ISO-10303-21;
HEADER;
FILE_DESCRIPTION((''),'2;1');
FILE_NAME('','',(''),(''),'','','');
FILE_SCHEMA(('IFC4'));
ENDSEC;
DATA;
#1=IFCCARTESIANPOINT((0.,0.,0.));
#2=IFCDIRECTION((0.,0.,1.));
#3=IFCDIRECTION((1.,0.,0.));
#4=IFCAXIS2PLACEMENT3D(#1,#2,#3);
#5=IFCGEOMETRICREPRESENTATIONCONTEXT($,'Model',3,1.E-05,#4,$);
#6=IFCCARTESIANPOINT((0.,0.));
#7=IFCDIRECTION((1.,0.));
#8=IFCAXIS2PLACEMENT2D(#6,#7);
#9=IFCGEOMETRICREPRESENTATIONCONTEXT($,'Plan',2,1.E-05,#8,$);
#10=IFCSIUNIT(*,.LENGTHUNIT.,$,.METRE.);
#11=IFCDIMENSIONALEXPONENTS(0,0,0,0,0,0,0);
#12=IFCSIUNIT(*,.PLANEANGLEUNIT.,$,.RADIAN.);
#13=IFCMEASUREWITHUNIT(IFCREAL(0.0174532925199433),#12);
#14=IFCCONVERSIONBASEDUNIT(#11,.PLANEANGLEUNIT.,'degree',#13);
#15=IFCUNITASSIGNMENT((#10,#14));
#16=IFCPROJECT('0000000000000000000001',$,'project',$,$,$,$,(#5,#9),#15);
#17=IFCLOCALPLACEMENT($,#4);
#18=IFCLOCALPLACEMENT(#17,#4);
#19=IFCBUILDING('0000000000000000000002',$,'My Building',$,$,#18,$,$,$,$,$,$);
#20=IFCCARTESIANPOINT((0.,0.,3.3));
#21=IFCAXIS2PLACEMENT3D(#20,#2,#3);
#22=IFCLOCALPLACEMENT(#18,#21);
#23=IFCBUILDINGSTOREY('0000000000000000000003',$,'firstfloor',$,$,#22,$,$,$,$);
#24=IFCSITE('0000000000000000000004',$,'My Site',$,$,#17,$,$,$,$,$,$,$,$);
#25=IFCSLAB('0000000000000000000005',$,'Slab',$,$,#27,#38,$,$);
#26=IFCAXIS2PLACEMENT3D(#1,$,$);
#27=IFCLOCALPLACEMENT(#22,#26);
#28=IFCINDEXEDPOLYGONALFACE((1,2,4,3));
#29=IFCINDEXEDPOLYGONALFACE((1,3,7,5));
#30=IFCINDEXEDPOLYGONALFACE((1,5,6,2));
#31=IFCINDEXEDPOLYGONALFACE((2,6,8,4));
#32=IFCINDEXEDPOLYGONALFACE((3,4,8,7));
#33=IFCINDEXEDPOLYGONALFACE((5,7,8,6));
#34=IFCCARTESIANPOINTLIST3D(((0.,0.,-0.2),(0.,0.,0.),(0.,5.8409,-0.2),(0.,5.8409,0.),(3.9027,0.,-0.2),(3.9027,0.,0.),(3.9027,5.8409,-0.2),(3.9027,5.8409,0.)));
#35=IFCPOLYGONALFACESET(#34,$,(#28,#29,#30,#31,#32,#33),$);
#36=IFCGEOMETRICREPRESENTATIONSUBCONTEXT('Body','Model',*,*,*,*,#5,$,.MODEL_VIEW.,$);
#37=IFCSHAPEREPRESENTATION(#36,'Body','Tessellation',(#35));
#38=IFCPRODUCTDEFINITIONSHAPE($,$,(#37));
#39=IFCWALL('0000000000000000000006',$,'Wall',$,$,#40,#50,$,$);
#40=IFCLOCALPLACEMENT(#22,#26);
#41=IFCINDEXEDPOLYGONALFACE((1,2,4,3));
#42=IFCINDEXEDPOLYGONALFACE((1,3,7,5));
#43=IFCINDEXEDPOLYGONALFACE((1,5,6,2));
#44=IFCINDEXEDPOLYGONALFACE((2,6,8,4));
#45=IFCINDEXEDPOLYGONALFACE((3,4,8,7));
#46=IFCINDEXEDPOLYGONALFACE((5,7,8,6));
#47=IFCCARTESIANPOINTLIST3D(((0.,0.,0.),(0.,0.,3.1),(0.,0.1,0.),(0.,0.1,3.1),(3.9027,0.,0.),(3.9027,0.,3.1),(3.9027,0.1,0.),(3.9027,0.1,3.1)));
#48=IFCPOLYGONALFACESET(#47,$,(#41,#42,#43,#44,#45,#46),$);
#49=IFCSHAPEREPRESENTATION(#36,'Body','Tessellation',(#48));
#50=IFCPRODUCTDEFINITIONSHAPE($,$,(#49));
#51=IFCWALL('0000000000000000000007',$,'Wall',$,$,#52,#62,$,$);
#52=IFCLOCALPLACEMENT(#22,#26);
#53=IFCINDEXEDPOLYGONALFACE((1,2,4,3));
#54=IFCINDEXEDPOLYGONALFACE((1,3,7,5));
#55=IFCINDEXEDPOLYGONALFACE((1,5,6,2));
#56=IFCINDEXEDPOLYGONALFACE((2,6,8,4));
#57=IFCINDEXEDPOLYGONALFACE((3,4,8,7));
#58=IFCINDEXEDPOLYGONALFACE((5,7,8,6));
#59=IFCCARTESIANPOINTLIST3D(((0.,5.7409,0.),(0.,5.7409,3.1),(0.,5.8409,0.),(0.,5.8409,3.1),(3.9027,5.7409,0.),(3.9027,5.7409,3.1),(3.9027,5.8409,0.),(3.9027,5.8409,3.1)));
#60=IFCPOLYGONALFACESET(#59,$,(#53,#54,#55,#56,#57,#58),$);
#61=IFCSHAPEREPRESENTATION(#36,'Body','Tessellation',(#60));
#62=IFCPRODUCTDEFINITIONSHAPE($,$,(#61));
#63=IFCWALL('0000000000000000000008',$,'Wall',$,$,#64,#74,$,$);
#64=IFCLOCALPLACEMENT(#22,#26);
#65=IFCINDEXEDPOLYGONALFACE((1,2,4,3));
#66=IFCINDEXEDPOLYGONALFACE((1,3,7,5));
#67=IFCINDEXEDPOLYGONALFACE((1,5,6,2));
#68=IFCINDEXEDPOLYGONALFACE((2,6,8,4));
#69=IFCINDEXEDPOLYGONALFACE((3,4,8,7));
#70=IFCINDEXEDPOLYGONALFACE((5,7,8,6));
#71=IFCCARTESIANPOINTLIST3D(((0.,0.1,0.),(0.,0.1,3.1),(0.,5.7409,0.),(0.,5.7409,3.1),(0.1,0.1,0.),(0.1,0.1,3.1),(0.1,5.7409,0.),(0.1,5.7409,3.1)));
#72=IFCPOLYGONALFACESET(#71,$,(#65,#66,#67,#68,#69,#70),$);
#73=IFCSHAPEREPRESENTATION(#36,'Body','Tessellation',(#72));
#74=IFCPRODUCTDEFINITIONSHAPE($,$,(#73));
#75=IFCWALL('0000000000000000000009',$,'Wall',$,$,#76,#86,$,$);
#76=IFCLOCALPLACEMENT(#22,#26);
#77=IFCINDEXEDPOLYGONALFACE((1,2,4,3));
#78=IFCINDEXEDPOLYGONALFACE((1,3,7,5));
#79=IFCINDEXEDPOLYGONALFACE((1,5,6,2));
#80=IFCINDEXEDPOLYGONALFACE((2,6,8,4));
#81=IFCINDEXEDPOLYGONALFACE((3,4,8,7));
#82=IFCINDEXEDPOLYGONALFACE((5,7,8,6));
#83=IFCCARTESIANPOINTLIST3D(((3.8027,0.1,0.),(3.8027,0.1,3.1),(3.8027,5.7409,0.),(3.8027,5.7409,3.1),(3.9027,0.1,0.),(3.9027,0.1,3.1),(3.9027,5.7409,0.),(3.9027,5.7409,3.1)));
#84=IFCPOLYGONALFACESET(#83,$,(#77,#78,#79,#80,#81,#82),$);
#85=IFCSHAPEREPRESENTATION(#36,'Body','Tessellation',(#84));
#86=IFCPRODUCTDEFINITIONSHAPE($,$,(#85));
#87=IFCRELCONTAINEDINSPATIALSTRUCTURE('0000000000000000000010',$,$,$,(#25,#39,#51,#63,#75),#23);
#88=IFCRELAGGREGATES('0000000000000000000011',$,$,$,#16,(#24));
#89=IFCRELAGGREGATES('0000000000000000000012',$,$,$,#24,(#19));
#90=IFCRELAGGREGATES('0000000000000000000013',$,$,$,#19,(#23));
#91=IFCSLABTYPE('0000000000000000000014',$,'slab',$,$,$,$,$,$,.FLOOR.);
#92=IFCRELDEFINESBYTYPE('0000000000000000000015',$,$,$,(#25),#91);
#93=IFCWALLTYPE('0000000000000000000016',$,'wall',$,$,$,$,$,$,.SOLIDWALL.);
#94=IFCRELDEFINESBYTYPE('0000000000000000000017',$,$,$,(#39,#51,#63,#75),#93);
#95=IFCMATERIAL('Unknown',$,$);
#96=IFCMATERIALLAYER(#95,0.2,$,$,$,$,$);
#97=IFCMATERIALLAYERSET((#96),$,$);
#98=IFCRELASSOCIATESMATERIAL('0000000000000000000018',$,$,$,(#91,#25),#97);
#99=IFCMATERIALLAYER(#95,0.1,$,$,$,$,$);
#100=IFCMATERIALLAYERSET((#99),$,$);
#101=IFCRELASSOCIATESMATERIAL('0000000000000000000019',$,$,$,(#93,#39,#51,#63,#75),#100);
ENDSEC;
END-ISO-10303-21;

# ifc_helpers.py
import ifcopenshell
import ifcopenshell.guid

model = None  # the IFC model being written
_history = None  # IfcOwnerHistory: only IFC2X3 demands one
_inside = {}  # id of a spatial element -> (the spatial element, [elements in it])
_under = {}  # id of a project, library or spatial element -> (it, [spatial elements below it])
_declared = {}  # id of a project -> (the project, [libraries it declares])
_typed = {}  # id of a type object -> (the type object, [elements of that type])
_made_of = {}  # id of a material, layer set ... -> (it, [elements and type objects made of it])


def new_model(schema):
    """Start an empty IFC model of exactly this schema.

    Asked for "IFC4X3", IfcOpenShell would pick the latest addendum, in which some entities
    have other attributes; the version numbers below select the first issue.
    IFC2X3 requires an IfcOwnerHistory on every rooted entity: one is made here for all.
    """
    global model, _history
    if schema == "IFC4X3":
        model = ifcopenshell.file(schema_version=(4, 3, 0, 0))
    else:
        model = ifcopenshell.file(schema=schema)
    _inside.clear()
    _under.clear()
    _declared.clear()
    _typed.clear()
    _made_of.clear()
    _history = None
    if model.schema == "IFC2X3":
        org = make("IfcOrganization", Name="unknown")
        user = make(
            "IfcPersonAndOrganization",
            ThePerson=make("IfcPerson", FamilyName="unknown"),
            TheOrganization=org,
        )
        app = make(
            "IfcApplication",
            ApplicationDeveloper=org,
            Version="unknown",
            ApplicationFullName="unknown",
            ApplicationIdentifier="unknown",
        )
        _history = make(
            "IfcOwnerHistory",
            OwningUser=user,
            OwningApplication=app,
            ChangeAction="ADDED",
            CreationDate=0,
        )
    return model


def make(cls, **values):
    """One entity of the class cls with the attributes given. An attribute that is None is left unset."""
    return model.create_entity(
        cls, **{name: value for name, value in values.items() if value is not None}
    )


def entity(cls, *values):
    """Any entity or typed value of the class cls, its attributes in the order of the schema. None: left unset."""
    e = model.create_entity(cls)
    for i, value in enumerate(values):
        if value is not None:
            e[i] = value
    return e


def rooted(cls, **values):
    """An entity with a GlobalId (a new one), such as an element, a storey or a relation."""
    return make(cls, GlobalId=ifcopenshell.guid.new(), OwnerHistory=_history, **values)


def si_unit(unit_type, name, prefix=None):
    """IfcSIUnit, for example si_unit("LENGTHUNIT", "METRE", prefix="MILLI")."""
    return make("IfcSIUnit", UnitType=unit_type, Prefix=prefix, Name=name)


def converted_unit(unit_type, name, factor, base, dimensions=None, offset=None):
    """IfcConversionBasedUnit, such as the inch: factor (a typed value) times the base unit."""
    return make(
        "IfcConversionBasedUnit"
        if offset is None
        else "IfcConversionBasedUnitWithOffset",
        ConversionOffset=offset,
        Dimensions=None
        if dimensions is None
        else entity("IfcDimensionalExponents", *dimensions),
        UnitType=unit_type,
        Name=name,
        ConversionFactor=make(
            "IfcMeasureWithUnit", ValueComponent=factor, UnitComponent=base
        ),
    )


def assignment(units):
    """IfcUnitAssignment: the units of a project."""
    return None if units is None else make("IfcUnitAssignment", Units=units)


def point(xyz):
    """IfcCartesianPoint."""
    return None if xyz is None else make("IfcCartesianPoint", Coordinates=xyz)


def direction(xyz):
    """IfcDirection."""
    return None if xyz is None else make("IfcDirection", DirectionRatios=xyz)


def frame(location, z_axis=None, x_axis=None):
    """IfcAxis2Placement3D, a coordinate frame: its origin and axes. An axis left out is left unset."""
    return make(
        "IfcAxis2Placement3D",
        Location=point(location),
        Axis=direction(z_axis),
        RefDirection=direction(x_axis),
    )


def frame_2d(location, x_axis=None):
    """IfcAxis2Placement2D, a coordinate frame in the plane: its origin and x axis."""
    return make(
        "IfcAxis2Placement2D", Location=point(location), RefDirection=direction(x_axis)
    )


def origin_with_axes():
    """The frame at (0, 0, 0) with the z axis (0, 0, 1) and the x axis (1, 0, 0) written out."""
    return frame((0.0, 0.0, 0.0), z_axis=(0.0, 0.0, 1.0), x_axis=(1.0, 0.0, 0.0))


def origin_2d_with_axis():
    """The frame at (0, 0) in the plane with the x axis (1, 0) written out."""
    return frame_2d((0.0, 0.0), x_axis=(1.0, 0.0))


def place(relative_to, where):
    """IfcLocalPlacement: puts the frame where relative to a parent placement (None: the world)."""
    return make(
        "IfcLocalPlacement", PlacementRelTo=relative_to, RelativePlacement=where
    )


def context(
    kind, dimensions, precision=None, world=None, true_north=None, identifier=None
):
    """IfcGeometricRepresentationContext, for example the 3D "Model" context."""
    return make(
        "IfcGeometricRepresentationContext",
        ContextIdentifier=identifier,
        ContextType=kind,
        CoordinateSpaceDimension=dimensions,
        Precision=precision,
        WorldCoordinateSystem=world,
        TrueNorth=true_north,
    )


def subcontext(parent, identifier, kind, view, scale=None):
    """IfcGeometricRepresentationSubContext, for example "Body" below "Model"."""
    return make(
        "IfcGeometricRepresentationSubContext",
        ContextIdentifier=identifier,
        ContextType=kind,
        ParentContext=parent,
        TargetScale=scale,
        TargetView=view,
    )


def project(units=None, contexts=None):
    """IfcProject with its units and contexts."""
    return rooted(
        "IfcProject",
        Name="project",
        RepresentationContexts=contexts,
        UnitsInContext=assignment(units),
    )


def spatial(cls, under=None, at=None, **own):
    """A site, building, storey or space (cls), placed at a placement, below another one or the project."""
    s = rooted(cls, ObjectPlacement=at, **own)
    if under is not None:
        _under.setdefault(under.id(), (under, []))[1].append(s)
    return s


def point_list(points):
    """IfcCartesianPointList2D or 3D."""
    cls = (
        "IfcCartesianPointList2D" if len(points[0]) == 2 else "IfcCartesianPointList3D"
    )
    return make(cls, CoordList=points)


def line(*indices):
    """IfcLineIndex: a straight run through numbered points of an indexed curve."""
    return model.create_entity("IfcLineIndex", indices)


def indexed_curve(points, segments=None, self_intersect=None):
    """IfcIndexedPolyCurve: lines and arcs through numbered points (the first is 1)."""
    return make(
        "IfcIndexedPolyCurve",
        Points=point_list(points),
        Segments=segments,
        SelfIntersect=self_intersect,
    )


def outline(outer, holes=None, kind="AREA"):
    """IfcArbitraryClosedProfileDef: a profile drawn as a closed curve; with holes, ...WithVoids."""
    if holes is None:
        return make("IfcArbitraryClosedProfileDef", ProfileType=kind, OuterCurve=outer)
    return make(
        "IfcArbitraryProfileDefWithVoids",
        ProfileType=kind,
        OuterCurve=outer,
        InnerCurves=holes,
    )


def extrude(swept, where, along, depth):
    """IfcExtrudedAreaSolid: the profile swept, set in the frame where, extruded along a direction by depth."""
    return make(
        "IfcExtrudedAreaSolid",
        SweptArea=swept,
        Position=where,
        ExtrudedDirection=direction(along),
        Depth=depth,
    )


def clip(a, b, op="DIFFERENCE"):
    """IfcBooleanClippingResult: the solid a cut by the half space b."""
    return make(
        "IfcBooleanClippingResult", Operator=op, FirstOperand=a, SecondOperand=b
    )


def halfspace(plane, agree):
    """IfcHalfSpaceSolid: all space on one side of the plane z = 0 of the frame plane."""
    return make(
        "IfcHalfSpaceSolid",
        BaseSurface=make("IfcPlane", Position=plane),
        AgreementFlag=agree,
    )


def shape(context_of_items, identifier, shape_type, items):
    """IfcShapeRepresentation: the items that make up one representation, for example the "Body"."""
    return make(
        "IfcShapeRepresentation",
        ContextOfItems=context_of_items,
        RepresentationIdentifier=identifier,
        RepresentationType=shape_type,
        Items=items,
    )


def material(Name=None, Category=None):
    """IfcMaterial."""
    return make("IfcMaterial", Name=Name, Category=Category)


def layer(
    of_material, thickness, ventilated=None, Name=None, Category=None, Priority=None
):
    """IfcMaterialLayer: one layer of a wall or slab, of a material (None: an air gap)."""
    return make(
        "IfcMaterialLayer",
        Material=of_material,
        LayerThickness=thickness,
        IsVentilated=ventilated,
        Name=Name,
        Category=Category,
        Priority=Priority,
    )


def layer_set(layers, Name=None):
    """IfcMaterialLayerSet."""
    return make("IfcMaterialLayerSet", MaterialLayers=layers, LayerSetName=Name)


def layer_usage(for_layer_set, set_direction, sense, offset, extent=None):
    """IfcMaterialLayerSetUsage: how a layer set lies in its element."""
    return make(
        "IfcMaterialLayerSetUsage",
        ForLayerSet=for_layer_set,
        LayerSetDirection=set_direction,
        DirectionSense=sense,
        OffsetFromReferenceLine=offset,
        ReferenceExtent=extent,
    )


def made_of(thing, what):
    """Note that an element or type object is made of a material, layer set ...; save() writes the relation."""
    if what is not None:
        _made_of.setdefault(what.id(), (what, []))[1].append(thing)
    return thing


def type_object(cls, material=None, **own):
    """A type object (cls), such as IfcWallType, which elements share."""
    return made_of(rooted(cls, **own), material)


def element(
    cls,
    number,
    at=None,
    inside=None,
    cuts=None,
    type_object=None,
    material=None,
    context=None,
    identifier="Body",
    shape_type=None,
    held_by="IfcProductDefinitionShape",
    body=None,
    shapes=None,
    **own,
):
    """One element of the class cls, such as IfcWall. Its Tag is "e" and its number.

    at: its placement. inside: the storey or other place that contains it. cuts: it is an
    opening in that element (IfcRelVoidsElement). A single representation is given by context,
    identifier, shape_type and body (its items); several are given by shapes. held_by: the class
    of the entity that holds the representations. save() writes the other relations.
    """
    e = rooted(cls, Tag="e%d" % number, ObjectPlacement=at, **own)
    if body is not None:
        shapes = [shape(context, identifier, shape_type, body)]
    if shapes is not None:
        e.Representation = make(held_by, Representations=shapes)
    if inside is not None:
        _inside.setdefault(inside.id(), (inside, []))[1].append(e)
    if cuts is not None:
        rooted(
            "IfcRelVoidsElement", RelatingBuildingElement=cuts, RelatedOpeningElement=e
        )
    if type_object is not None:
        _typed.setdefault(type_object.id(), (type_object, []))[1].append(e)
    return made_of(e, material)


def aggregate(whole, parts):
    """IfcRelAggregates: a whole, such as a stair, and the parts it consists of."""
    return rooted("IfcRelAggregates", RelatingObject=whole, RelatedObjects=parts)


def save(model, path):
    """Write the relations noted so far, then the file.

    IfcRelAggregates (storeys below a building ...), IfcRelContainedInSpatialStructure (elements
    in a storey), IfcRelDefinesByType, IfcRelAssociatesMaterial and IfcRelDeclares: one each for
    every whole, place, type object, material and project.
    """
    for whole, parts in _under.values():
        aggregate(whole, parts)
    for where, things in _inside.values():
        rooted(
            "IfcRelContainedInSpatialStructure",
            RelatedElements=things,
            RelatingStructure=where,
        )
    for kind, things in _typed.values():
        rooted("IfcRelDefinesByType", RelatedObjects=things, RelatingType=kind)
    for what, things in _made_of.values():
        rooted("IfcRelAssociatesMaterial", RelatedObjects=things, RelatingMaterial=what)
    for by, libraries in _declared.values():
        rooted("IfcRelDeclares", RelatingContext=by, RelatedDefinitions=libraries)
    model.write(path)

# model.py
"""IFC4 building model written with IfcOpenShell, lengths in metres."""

from ifc_helpers import new_model, entity, si_unit, converted_unit, frame, origin_with_axes, origin_2d_with_axis, place, context, subcontext, project, spatial, line, indexed_curve, outline, extrude, clip, halfspace, material, layer, layer_set, layer_usage, type_object, element, save


model = new_model("IFC4")

# Units and contexts
model_context = context("Model", 3, precision=1e-05, world=origin_with_axes())
plan_context = context("Plan", 2, precision=1e-05, world=origin_2d_with_axis())
body_context = subcontext(model_context, "Body", "Model", "MODEL_VIEW")
ifc_project = project(units=[si_unit("LENGTHUNIT", "METRE"), converted_unit("PLANEANGLEUNIT", "degree", entity("IfcReal", 0.0174532925199433), si_unit("PLANEANGLEUNIT", "RADIAN"), dimensions=[0, 0, 0, 0, 0, 0, 0])], contexts=[model_context, plan_context])

# Site, building, storey
site_placement = place(None, origin_with_axes())
site = spatial("IfcSite", under=ifc_project, at=site_placement, Name="My Site")
building_placement = place(site_placement, origin_with_axes())
building = spatial("IfcBuilding", under=site, at=building_placement, Name="My Building")
storey_placement = place(building_placement, frame((0.0, 0.0, 3.3), z_axis=(0.0, 0.0, 1.0), x_axis=(1.0, 0.0, 0.0)))
storey = spatial("IfcBuildingStorey", under=building, at=storey_placement, Name="firstfloor")

# Slab
ifc_material = material(Name="Unknown")
ifc_layer_1 = layer(ifc_material, 0.2)
ifc_layer_set_1 = layer_set([ifc_layer_1])
ifc_layer_usage_1 = layer_usage(ifc_layer_set_1, "AXIS3", "POSITIVE", 0.0)
slab_type = type_object("IfcSlabType", Name="slab", PredefinedType="FLOOR", material=ifc_layer_set_1)
slab_placement = place(storey_placement, frame((0.0, 0.0, -0.2), z_axis=(0.0, 0.0, 1.0), x_axis=(1.0, 0.0, 0.0)))
element("IfcSlab", 1, at=slab_placement, inside=storey, type_object=slab_type, material=ifc_layer_usage_1, Name="Slab", context=body_context, shape_type="SweptSolid", body=[
    extrude(outline(indexed_curve([(0.0, 0.0), (3.9027, 0.0), (3.9027, 5.8409), (0.0, 5.8409)], segments=[line(3, 2), line(2, 1), line(1, 4), line(4, 3)], self_intersect=False)), None, (0.0, 0.0, 1.0), 0.2),
])

# Walls
ifc_layer_2 = layer(ifc_material, 0.1)
ifc_layer_set_2 = layer_set([ifc_layer_2])
ifc_layer_usage_2 = layer_usage(ifc_layer_set_2, "AXIS2", "POSITIVE", 0.0)
wall_type = type_object("IfcWallType", Name="wall", PredefinedType="SOLIDWALL", material=ifc_layer_set_2)
wall_1_placement = place(storey_placement, origin_with_axes())
element("IfcWall", 2, at=wall_1_placement, inside=storey, type_object=wall_type, material=ifc_layer_usage_2, Name="Wall", context=body_context, shape_type="Clipping", body=[
    clip(extrude(outline(indexed_curve([(0.0, 0.0), (0.0, 0.1), (3.9027, 0.1), (3.9027, 0.0), (0.0, 0.0)], self_intersect=False)), origin_with_axes(), (0.0, 0.0, 1.0), 6.4), halfspace(frame((0.0, 0.0, 3.1), z_axis=(0.0, 0.0, 1.0), x_axis=(-1.0, 0.0, 0.0)), False)),
])
ifc_layer_usage_3 = layer_usage(ifc_layer_set_2, "AXIS2", "POSITIVE", 0.0)
wall_2_placement = place(storey_placement, frame((0.0, 5.7409, 0.0), z_axis=(0.0, 0.0, 1.0), x_axis=(1.0, 0.0, 0.0)))
element("IfcWall", 3, at=wall_2_placement, inside=storey, type_object=wall_type, material=ifc_layer_usage_3, Name="Wall", context=body_context, shape_type="Clipping", body=[
    clip(extrude(outline(indexed_curve([(0.0, 0.0), (0.0, 0.1), (3.9027, 0.1), (3.9027, 0.0), (0.0, 0.0)], self_intersect=False)), origin_with_axes(), (0.0, 0.0, 1.0), 6.4), halfspace(frame((0.0, 0.0, 3.1), z_axis=(0.0, 0.0, 1.0), x_axis=(-1.0, 0.0, 0.0)), False)),
])
ifc_layer_usage_4 = layer_usage(ifc_layer_set_2, "AXIS2", "POSITIVE", 0.0)
wall_3_placement = place(storey_placement, frame((0.0, 5.7409, 0.0), z_axis=(0.0, 0.0, 1.0), x_axis=(0.0, -1.0, 0.0)))
element("IfcWall", 4, at=wall_3_placement, inside=storey, type_object=wall_type, material=ifc_layer_usage_4, Name="Wall", context=body_context, shape_type="Clipping", body=[
    clip(extrude(outline(indexed_curve([(0.0, 0.0), (0.0, 0.1), (5.6409, 0.1), (5.6409, 0.0), (0.0, 0.0)], self_intersect=False)), origin_with_axes(), (0.0, 0.0, 1.0), 6.4), halfspace(frame((0.0, 0.0, 3.1), z_axis=(0.0, 0.0, 1.0), x_axis=(-1.0, 0.0, 0.0)), False)),
])
ifc_layer_usage_5 = layer_usage(ifc_layer_set_2, "AXIS2", "POSITIVE", 0.0)
wall_4_placement = place(storey_placement, frame((3.8027, 5.7409, 0.0), z_axis=(0.0, 0.0, 1.0), x_axis=(0.0, -1.0, 0.0)))
element("IfcWall", 5, at=wall_4_placement, inside=storey, type_object=wall_type, material=ifc_layer_usage_5, Name="Wall", context=body_context, shape_type="Clipping", body=[
    clip(extrude(outline(indexed_curve([(0.0, 0.0), (0.0, 0.1), (5.6409, 0.1), (5.6409, 0.0), (0.0, 0.0)], self_intersect=False)), origin_with_axes(), (0.0, 0.0, 1.0), 6.4), halfspace(frame((0.0, 0.0, 3.1), z_axis=(0.0, 0.0, 1.0), x_axis=(-1.0, 0.0, 0.0)), False)),
])

save(model, "model.ifc")
